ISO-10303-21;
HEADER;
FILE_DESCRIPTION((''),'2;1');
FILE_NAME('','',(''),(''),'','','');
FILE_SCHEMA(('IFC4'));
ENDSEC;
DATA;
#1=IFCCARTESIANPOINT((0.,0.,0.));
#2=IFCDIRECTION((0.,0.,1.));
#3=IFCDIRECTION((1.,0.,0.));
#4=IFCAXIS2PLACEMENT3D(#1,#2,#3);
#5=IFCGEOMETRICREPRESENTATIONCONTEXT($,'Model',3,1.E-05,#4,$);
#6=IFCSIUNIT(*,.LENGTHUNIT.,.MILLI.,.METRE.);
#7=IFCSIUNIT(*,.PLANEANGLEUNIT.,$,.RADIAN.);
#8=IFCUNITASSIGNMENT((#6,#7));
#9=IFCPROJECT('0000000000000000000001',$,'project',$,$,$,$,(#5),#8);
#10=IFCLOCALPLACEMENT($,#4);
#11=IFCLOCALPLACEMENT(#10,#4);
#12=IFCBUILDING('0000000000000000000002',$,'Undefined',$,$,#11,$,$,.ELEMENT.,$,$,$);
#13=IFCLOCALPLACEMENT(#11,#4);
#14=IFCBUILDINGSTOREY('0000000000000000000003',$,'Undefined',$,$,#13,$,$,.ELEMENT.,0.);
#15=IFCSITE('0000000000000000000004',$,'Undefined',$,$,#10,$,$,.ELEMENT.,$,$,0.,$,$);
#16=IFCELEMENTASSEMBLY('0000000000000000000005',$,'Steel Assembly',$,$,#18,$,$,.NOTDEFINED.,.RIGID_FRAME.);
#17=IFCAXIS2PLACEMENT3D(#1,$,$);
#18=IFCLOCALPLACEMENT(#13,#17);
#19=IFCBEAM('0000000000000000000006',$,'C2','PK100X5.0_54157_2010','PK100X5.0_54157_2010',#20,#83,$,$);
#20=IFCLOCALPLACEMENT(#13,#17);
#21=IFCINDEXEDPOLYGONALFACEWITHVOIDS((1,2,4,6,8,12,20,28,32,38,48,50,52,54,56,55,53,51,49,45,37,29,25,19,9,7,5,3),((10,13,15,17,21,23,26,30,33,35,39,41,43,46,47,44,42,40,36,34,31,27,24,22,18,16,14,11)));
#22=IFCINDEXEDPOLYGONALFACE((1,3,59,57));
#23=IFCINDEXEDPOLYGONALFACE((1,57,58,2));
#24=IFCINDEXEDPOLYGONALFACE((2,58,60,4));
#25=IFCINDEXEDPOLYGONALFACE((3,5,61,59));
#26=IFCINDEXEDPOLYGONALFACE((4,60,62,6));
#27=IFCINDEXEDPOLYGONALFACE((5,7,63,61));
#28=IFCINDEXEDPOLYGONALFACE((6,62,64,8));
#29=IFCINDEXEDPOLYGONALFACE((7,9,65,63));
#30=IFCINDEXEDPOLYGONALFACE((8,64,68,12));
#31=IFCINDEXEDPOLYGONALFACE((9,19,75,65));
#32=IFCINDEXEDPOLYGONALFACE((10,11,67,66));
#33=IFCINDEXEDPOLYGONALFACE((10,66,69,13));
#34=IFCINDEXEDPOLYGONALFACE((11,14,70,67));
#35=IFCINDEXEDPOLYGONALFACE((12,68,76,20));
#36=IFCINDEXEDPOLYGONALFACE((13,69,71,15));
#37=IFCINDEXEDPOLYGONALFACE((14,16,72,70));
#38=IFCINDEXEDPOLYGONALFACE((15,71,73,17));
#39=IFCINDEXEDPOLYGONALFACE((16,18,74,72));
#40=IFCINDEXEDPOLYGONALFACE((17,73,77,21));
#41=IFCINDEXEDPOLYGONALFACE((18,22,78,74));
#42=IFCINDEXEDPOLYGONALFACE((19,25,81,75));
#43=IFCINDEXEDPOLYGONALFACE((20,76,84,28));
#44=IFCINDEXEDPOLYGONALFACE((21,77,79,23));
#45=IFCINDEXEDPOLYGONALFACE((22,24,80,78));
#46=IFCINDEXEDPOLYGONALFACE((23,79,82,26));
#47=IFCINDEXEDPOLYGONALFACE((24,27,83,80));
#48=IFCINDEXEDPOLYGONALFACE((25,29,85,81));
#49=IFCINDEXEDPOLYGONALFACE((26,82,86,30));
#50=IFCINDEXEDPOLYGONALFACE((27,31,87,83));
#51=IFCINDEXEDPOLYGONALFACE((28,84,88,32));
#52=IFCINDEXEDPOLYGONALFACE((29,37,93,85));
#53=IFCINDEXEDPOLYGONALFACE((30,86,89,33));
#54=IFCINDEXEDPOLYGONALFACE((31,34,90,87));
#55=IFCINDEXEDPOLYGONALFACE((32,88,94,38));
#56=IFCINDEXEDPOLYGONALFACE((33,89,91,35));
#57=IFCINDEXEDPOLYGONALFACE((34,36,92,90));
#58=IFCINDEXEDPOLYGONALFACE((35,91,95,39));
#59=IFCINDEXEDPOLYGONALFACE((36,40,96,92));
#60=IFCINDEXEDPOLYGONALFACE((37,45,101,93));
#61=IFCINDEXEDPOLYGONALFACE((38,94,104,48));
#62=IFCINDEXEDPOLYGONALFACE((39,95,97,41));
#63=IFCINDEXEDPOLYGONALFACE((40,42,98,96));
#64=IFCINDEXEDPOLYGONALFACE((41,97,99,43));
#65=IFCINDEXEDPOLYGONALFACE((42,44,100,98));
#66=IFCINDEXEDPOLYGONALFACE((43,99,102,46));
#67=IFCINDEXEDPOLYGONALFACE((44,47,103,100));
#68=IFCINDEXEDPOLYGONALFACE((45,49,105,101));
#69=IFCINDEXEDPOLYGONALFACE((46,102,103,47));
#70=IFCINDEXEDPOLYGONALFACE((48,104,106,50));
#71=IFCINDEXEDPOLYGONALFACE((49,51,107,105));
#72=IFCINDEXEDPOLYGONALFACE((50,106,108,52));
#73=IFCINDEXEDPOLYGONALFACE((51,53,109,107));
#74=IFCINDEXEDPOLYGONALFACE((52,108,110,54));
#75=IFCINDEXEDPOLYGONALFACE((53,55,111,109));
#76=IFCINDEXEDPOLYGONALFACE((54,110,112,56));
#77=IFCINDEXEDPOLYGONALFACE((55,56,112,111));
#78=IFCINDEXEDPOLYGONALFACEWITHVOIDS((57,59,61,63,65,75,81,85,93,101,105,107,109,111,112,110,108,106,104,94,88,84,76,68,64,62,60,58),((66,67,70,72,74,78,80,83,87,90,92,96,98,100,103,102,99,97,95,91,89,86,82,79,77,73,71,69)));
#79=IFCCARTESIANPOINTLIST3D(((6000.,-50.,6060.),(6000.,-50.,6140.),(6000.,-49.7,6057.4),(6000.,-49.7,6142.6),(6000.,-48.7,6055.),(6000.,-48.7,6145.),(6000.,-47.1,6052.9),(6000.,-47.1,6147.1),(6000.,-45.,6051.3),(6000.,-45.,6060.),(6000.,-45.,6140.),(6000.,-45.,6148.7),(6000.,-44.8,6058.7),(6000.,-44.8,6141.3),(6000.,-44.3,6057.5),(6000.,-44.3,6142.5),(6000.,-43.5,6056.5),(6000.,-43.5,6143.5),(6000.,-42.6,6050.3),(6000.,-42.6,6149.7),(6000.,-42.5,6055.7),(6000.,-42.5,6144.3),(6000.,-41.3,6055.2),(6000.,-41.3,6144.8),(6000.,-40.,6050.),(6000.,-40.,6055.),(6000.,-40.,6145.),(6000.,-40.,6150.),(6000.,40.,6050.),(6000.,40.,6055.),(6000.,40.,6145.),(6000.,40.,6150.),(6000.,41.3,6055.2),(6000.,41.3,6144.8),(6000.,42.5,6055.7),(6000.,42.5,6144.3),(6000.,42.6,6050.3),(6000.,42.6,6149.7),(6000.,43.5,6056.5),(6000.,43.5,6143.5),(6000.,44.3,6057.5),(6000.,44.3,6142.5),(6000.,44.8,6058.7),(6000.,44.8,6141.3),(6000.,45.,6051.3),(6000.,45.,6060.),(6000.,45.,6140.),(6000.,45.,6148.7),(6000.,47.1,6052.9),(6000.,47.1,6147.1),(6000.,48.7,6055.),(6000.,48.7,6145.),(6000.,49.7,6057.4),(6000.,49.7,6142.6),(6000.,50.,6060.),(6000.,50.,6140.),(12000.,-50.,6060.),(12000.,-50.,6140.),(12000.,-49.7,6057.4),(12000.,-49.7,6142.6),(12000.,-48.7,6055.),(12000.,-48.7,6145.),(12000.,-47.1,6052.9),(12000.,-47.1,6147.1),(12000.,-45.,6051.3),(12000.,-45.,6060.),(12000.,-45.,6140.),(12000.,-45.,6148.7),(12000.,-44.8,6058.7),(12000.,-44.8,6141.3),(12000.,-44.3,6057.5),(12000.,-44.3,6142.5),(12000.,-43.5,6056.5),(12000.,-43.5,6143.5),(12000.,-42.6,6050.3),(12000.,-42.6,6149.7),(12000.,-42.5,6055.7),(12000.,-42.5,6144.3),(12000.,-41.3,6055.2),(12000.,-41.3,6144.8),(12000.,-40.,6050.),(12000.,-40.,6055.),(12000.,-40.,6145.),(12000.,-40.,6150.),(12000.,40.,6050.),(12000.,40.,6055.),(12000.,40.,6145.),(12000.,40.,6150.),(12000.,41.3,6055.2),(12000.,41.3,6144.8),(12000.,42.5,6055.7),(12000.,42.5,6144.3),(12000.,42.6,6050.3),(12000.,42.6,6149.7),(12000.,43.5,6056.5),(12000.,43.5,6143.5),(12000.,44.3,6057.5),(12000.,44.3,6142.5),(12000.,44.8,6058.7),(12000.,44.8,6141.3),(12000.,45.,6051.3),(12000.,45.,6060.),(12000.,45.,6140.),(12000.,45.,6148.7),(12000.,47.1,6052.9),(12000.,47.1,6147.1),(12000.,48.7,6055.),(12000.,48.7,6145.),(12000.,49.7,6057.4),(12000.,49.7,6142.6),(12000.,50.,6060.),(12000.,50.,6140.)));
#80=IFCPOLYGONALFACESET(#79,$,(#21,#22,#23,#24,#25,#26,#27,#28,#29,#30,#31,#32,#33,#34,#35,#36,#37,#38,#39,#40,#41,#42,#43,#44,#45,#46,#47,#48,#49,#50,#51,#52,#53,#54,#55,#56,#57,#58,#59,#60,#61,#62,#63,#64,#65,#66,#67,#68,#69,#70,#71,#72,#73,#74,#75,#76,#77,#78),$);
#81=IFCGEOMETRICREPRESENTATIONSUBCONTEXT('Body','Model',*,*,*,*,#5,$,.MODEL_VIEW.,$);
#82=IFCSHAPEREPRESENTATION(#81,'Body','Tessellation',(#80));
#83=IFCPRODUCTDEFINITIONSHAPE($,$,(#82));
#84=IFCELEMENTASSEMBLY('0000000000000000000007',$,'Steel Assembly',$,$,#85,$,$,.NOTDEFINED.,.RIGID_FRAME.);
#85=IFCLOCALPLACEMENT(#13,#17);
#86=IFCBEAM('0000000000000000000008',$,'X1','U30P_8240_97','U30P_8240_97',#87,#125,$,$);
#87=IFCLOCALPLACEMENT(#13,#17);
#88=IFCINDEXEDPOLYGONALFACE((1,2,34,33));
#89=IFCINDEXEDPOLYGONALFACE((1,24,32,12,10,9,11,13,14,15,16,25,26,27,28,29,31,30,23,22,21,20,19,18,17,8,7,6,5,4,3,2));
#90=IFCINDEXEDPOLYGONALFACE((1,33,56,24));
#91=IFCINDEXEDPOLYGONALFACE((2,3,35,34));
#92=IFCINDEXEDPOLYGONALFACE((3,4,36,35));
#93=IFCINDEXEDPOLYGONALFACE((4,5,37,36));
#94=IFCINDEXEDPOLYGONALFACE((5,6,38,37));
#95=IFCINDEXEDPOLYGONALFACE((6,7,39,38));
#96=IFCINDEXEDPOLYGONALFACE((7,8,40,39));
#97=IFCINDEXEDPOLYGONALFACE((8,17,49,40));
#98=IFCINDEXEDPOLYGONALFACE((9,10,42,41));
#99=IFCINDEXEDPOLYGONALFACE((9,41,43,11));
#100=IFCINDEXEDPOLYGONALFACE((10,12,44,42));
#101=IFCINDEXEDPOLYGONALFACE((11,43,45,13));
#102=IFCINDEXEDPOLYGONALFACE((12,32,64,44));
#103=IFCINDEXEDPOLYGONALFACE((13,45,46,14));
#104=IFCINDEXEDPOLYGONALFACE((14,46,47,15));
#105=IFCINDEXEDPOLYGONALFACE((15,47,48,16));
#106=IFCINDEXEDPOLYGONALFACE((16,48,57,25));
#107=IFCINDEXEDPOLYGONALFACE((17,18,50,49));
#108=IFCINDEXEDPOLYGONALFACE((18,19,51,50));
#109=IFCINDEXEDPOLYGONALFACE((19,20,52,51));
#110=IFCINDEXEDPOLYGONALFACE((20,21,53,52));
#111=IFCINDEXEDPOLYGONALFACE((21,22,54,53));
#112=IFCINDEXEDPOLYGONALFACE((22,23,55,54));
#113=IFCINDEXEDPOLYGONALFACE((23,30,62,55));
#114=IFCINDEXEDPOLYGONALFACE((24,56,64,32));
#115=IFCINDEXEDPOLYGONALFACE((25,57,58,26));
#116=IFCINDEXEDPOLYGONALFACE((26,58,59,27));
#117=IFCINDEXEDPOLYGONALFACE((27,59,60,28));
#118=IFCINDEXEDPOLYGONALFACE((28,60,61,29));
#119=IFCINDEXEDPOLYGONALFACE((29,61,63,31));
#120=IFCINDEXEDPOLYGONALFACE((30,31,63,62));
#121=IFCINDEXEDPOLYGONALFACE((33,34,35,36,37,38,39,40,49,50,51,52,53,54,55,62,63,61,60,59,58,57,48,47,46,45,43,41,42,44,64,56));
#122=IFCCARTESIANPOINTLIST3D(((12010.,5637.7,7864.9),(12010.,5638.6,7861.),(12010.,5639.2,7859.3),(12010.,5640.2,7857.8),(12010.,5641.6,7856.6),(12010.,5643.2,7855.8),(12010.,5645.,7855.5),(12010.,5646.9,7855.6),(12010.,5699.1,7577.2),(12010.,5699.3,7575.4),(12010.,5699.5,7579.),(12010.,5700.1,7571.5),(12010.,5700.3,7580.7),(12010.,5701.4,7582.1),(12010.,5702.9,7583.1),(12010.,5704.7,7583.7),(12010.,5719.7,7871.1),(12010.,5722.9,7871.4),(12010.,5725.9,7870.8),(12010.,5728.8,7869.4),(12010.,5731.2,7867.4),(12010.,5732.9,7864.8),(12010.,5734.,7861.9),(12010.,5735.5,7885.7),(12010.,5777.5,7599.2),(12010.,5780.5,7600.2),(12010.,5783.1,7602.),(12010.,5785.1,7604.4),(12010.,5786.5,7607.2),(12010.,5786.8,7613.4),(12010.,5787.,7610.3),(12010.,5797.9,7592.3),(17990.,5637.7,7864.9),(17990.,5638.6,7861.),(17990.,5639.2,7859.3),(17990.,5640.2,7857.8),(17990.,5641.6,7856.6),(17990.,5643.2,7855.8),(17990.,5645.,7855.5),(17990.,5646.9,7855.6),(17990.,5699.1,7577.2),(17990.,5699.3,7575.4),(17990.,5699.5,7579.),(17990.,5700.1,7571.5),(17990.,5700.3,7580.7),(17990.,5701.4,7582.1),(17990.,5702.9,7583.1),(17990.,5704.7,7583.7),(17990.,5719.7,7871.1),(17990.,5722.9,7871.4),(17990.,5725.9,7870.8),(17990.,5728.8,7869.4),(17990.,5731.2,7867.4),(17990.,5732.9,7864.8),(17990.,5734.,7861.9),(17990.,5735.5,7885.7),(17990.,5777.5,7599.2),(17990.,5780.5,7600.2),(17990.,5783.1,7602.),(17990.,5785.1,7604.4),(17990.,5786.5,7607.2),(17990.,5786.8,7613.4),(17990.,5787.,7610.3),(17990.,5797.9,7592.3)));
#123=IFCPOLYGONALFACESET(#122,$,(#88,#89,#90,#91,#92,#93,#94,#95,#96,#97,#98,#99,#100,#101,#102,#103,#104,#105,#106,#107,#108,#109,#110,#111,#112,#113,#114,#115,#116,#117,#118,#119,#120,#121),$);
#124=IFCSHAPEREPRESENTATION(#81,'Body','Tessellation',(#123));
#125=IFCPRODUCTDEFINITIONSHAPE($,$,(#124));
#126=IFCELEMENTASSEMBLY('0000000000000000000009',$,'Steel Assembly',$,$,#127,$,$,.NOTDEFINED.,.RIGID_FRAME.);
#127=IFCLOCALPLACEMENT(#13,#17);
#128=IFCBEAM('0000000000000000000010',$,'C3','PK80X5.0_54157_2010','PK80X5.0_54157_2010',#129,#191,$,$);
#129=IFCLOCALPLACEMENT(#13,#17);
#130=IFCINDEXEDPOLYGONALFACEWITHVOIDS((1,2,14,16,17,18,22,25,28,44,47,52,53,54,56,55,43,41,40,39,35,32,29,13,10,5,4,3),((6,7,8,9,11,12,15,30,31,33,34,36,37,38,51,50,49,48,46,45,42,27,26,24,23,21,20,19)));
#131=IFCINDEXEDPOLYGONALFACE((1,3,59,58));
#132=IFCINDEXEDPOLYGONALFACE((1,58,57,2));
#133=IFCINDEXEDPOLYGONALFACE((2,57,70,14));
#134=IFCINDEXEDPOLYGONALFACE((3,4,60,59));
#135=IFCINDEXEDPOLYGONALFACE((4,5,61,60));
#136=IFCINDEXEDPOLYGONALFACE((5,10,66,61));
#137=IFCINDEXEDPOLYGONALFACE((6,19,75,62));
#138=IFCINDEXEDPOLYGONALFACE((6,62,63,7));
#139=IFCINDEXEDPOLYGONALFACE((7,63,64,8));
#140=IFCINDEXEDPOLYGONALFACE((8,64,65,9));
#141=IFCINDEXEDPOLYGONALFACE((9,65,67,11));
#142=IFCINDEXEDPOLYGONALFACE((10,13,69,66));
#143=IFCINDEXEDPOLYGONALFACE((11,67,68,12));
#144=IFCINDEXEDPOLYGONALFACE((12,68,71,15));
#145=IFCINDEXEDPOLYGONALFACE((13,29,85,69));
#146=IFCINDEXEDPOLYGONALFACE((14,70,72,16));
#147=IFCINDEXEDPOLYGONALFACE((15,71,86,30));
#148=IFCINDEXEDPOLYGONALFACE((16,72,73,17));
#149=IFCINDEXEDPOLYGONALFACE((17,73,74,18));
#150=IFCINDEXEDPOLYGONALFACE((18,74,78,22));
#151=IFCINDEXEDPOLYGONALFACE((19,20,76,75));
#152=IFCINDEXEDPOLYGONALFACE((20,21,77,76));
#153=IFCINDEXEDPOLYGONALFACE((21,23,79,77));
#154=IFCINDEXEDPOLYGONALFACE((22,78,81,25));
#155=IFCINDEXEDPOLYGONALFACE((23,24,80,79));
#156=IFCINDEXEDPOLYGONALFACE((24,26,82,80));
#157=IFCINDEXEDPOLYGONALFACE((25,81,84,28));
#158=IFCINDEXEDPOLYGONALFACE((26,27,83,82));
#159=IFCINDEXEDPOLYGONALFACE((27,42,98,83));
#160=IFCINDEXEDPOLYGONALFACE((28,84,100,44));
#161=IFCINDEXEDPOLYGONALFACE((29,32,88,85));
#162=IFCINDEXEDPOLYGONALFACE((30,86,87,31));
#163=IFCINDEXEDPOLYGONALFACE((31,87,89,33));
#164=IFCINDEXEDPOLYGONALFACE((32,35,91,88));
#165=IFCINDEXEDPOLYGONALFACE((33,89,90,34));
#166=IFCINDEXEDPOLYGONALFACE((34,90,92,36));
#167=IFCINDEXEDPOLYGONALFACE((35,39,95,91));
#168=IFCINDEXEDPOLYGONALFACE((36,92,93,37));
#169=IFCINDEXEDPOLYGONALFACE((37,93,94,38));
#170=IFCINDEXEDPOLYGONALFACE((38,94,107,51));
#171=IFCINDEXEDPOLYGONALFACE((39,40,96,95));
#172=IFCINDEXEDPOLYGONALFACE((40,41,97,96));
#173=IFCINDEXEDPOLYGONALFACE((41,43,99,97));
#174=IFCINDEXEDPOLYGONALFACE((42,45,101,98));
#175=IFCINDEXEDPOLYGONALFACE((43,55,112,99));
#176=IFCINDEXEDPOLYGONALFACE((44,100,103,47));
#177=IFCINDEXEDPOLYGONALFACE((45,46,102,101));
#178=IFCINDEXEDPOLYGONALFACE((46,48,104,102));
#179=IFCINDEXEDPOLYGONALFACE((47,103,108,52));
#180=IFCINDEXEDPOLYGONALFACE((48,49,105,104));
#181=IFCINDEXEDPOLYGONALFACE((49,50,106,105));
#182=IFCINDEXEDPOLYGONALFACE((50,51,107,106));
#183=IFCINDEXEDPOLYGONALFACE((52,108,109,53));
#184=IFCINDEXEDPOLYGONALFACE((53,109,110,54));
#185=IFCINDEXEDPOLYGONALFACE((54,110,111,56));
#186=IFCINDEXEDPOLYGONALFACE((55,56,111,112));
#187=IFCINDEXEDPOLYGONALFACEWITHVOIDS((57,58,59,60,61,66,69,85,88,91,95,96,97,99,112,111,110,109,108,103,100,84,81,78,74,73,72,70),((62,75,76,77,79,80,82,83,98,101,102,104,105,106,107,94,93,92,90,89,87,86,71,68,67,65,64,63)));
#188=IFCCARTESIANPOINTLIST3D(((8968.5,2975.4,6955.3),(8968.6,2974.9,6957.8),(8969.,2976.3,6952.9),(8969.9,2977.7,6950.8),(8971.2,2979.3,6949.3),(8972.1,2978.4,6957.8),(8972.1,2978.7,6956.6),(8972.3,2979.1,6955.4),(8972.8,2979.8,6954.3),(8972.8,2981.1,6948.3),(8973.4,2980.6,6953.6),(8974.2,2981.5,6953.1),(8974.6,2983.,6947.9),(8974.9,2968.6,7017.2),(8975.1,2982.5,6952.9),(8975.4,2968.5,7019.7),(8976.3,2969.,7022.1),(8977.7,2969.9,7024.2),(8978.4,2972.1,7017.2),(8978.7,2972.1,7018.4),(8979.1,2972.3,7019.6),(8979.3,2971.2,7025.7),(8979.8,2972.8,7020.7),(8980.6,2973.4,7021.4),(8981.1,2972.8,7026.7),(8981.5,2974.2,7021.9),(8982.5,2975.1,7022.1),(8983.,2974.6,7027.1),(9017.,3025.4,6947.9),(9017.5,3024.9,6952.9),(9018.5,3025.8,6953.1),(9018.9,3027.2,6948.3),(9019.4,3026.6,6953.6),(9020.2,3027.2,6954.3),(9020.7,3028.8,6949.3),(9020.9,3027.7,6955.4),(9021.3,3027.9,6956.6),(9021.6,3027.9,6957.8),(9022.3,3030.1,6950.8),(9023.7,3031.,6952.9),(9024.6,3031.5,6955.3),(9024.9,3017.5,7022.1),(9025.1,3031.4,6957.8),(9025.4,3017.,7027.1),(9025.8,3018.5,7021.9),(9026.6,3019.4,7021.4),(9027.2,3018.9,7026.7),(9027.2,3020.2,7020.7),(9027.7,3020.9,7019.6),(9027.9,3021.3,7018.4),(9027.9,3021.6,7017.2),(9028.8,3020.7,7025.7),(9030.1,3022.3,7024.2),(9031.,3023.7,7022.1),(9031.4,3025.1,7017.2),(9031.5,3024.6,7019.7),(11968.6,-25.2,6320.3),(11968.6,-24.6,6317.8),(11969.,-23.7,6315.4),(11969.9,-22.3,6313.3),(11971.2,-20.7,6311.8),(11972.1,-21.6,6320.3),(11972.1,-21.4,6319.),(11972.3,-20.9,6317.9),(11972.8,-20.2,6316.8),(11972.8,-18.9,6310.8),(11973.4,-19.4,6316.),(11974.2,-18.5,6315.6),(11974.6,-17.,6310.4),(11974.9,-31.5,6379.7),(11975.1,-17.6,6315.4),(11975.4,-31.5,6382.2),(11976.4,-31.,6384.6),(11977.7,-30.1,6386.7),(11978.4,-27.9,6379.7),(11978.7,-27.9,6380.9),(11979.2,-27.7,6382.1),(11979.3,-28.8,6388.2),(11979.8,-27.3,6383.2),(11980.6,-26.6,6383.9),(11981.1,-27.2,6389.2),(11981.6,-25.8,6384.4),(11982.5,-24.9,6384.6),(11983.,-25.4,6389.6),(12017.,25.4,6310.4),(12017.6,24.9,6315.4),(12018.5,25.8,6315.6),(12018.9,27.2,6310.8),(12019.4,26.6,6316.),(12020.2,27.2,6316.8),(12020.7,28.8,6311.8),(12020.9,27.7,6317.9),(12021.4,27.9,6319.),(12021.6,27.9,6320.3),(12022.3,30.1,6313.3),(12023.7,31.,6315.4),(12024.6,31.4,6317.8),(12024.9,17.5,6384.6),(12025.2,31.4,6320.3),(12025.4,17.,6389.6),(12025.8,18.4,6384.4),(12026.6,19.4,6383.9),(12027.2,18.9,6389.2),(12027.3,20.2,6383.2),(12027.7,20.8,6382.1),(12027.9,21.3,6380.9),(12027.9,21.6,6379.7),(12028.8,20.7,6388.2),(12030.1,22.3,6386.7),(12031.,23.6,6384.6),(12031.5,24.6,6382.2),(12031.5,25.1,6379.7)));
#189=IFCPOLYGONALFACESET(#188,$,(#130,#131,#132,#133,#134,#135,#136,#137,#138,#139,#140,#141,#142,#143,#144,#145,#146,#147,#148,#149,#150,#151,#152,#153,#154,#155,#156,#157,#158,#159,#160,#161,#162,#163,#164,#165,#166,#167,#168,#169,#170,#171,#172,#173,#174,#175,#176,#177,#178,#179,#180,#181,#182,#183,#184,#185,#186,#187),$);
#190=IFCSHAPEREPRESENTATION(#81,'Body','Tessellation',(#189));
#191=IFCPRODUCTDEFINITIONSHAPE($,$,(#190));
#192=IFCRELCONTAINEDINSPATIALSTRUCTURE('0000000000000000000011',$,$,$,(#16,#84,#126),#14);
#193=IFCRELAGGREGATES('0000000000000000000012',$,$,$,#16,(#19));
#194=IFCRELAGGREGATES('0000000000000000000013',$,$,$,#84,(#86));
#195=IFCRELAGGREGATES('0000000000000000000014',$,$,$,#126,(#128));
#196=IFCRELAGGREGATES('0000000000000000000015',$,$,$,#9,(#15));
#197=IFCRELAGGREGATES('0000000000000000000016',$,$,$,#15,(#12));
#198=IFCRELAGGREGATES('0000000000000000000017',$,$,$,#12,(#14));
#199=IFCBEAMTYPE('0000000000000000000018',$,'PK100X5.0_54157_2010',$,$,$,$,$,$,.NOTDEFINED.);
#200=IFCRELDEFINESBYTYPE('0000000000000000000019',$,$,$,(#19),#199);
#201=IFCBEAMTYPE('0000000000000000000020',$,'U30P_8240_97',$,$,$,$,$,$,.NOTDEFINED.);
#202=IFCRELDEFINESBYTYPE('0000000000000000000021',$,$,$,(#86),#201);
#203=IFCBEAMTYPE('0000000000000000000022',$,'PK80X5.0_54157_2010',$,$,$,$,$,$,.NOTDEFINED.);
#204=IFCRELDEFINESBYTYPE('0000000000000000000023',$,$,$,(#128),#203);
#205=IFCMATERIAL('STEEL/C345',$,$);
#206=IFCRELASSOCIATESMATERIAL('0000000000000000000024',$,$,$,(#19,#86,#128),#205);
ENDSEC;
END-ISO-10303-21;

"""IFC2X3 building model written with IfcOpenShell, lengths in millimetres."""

from ifc_helpers import new_model, si_unit, frame, origin_with_axes, origin_2d_with_axis, place, context, subcontext, project, spatial, hollow_rectangle, u_section, extrude, material, type_object, element, aggregate, save


model = new_model("IFC2X3")

# Units and contexts
model_context = context("Model", 3, precision=1e-05, world=origin_with_axes())
body_context = subcontext(model_context, "Body", "Model", "MODEL_VIEW")
ifc_project = project(units=[si_unit("LENGTHUNIT", "METRE", prefix="MILLI"), si_unit("PLANEANGLEUNIT", "RADIAN")], contexts=[model_context])

# Site, building, storey
site_placement = place(None, origin_with_axes())
site = spatial("IfcSite", under=ifc_project, at=site_placement, Name="Undefined", CompositionType="ELEMENT", RefElevation=0.0)
building_placement = place(site_placement, origin_with_axes())
building = spatial("IfcBuilding", under=site, at=building_placement, Name="Undefined", CompositionType="ELEMENT")
storey_placement = place(building_placement, origin_with_axes())
storey = spatial("IfcBuildingStorey", under=building, at=storey_placement, Name="Undefined", CompositionType="ELEMENT", Elevation=0.0)

# Element assemblies, beams
assembly_1_placement = place(storey_placement, origin_with_axes())
assembly_1 = element("IfcElementAssembly", 1, at=assembly_1_placement, inside=storey, Name="Steel Assembly", AssemblyPlace="NOTDEFINED", PredefinedType="RIGID_FRAME")
ifc_material = material(Name="STEEL/C345")
beam_type_1 = type_object("IfcBeamType", Name="PK100X5.0_54157_2010", PredefinedType="NOTDEFINED")
beam_1_placement = place(assembly_1_placement, frame((12000.0, 0.0, 6100.0), z_axis=(0.0, 0.0, 1.0), x_axis=(-1.0, 0.0, 0.0)))
beam_1 = element("IfcBeam", 2, at=beam_1_placement, type_object=beam_type_1, material=ifc_material, Name="C2", Description="PK100X5.0_54157_2010", ObjectType="PK100X5.0_54157_2010", context=body_context, shape_type="SweptSolid", body=[
    extrude(hollow_rectangle(XDim=100.0, YDim=100.0, WallThickness=5.0, InnerFilletRadius=5.0, OuterFilletRadius=10.0, at=origin_2d_with_axis()), frame((6000.0, 0.0, 0.0), z_axis=(-1.0, 0.0, 0.0), x_axis=(0.0, -1.0, 0.0)), (0.0, 0.0, 1.0), 6000.0),
])
aggregate(assembly_1, [beam_1])
assembly_2_placement = place(storey_placement, origin_with_axes())
assembly_2 = element("IfcElementAssembly", 3, at=assembly_2_placement, inside=storey, Name="Steel Assembly", AssemblyPlace="NOTDEFINED", PredefinedType="RIGID_FRAME")
beam_type_2 = type_object("IfcBeamType", Name="U30P_8240_97", PredefinedType="NOTDEFINED")
beam_2_placement = place(assembly_2_placement, frame((12010.0, 5717.8, 7728.6), z_axis=(0.0, -0.207912, 0.978148), x_axis=(1.0, 0.0, 0.0)))
beam_2 = element("IfcBeam", 4, at=beam_2_placement, type_object=beam_type_2, material=ifc_material, Name="X1", Description="U30P_8240_97", ObjectType="U30P_8240_97", context=body_context, shape_type="SweptSolid", body=[
    extrude(u_section(Depth=300.0, FlangeWidth=100.0, WebThickness=6.5, FlangeThickness=11.0, FilletRadius=12.0, EdgeRadius=7.0, at=origin_2d_with_axis()), frame((5980.0, 0.0, 0.0), z_axis=(-1.0, 0.0, 0.0), x_axis=(0.0, -1.0, 0.0)), (0.0, 0.0, 1.0), 5980.0),
])
aggregate(assembly_2, [beam_2])
assembly_3_placement = place(storey_placement, origin_with_axes())
assembly_3 = element("IfcElementAssembly", 5, at=assembly_3_placement, inside=storey, Name="Steel Assembly", AssemblyPlace="NOTDEFINED", PredefinedType="RIGID_FRAME")
beam_type_3 = type_object("IfcBeamType", Name="PK80X5.0_54157_2010", PredefinedType="NOTDEFINED")
beam_3_placement = place(assembly_3_placement, frame((12000.0, 0.0, 6350.0), z_axis=(0.10507, -0.10507, 0.988899), x_axis=(-0.699257, 0.699257, 0.148592)))
beam_3 = element("IfcBeam", 6, at=beam_3_placement, type_object=beam_type_3, material=ifc_material, Name="C3", Description="PK80X5.0_54157_2010", ObjectType="PK80X5.0_54157_2010", context=body_context, shape_type="SweptSolid", body=[
    extrude(hollow_rectangle(XDim=80.0, YDim=80.0, WallThickness=5.0, InnerFilletRadius=5.0, OuterFilletRadius=10.0, at=origin_2d_with_axis()), frame((4290.3, 0.0, 0.0), z_axis=(-1.0, 0.0, 0.0), x_axis=(0.0, -1.0, 0.0)), (0.0, 0.0, 1.0), 4290.3),
])
aggregate(assembly_3, [beam_3])

save(model, "model.ifc")
